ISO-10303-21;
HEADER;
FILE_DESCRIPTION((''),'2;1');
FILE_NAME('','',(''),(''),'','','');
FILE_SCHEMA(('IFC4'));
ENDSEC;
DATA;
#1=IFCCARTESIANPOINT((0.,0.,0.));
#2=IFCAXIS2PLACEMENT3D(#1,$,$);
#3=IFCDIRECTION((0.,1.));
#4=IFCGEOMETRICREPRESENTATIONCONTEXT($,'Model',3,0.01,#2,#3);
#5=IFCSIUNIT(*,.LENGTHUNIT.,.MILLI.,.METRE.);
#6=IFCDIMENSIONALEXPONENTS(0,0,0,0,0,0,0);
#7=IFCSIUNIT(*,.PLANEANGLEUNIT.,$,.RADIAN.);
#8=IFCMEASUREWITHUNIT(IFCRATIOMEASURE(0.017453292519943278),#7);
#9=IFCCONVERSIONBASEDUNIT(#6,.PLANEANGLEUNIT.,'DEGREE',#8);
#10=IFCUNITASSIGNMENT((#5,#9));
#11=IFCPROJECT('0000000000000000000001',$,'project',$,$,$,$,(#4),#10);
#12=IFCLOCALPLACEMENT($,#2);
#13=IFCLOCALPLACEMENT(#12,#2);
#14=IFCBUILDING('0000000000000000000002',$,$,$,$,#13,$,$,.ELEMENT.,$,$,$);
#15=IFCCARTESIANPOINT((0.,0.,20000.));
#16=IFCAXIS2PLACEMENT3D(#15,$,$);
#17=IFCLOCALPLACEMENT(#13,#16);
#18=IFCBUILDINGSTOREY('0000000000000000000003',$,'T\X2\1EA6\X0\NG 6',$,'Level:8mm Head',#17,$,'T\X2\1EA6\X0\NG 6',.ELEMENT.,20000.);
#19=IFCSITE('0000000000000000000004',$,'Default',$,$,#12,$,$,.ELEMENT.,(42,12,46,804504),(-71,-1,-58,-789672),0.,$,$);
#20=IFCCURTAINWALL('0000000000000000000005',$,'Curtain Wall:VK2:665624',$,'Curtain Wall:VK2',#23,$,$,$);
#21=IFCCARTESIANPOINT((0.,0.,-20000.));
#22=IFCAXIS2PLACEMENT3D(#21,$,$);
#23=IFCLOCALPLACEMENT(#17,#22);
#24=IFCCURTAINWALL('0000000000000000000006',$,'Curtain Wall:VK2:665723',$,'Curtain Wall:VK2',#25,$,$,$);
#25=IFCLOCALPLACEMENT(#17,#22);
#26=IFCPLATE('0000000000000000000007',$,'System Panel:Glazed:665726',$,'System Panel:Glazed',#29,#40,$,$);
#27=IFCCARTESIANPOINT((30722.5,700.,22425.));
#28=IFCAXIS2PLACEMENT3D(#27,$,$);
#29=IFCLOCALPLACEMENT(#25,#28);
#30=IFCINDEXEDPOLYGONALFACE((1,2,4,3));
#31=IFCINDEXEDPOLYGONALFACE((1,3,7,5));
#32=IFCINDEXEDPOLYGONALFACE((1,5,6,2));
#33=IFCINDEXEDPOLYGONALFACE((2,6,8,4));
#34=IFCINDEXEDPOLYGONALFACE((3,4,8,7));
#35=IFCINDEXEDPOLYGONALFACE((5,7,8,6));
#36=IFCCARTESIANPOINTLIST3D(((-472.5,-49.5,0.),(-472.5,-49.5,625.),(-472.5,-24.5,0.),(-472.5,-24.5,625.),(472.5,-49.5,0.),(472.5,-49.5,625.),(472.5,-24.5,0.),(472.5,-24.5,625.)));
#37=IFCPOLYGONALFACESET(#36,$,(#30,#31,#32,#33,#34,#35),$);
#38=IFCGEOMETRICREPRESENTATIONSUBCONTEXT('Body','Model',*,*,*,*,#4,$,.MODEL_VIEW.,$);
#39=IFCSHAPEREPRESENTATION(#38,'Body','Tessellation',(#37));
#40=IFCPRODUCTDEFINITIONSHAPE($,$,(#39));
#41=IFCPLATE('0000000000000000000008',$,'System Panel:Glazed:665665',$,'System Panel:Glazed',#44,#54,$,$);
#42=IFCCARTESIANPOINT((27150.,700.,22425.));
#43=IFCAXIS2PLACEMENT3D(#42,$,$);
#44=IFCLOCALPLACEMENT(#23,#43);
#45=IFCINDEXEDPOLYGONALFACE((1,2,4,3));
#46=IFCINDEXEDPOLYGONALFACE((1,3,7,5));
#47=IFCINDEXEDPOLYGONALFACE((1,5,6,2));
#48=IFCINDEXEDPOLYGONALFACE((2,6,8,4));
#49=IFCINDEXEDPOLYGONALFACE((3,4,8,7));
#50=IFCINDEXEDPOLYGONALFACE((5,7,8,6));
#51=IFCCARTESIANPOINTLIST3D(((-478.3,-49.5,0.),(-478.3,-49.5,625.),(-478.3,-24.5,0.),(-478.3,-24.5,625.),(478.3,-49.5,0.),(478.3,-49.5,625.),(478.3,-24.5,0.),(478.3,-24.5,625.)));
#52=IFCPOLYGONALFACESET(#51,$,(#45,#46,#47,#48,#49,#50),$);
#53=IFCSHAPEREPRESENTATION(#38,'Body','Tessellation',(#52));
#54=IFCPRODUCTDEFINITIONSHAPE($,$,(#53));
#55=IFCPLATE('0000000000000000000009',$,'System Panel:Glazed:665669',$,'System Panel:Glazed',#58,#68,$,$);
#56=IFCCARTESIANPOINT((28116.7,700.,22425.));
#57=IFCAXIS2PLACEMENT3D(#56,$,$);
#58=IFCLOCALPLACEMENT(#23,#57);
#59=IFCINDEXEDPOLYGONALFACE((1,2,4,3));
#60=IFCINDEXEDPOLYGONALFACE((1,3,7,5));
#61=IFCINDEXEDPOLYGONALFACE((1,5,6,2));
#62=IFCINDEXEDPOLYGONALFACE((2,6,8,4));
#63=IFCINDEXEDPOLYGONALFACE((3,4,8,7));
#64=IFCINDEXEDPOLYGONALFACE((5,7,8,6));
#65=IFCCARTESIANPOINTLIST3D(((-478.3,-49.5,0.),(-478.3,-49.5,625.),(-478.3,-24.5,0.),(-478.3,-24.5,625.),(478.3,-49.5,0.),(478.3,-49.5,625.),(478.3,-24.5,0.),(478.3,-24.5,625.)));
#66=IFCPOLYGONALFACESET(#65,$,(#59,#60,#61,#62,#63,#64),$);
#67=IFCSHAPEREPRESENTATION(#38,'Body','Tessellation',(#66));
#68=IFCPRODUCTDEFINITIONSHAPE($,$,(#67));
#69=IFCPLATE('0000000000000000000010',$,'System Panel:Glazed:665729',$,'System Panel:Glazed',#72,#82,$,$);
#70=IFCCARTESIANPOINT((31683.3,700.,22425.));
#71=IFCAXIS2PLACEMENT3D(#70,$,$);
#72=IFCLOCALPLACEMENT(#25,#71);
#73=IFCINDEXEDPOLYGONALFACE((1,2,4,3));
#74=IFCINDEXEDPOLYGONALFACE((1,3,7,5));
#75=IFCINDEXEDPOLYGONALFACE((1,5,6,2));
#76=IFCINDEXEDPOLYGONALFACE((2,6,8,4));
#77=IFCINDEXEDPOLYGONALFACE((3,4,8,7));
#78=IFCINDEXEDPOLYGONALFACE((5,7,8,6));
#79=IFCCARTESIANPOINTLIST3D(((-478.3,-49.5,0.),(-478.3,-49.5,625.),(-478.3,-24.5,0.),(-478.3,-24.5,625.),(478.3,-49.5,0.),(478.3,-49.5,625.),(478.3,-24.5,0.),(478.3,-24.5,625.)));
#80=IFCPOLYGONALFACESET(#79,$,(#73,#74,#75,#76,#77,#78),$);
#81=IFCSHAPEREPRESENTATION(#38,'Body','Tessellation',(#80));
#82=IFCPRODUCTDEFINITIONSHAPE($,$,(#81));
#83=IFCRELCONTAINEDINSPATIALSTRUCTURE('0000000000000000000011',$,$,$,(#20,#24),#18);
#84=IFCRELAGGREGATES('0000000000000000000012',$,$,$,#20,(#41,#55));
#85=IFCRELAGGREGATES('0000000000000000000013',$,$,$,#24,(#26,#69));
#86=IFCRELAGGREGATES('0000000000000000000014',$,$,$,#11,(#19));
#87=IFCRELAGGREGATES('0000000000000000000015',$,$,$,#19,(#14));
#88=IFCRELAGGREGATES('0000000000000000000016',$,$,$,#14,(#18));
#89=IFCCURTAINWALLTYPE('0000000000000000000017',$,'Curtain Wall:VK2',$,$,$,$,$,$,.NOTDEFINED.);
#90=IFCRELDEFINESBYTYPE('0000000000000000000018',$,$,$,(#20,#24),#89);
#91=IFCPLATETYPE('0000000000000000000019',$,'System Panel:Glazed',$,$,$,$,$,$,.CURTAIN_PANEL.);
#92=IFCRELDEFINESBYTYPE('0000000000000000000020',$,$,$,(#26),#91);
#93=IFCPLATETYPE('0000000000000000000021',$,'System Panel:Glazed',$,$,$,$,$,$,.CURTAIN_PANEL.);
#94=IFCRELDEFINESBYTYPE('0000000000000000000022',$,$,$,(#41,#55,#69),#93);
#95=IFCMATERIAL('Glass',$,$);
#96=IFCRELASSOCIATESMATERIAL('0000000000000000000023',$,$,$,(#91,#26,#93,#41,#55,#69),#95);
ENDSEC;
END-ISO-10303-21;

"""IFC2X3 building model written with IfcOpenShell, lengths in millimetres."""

from ifc_helpers import new_model, entity, si_unit, converted_unit, direction, frame, frame_2d, origin, place, context, subcontext, project, spatial, rectangle, extrude, source, transform, mapped, material, type_object, type_shapes, element, aggregate, save


model = new_model("IFC2X3")

# Units and contexts
model_context = context("Model", 3, precision=0.01, world=origin(), true_north=direction((0.0, 1.0)))
body_context = subcontext(model_context, "Body", "Model", "MODEL_VIEW")
ifc_project = project(units=[si_unit("LENGTHUNIT", "METRE", prefix="MILLI"), converted_unit("PLANEANGLEUNIT", "DEGREE", entity("IfcRatioMeasure", 0.017453292519943278), si_unit("PLANEANGLEUNIT", "RADIAN"), dimensions=[0, 0, 0, 0, 0, 0, 0])], contexts=[model_context])

# Site, building, storey
site_placement = place(None, origin())
site = spatial("IfcSite", under=ifc_project, at=site_placement, Name="Default", CompositionType="ELEMENT", RefLatitude=(42, 12, 46, 804504), RefLongitude=(-71, -1, -58, -789672), RefElevation=0.0)
building_placement = place(site_placement, origin())
building = spatial("IfcBuilding", under=site, at=building_placement, CompositionType="ELEMENT")
storey_placement = place(building_placement, frame((0.0, 0.0, 20000.0)))
storey = spatial("IfcBuildingStorey", under=building, at=storey_placement, Name="TẦNG 6", ObjectType="Level:8mm Head", LongName="TẦNG 6", CompositionType="ELEMENT", Elevation=20000.0)

# Curtain wall
curtain_wall_type = type_object("IfcCurtainWallType", Name="Curtain Wall:VK2", PredefinedType="NOTDEFINED")
curtain_wall_1_placement = place(storey_placement, frame((0.0, 0.0, -20000.0)))
curtain_wall_1 = element("IfcCurtainWall", 1, at=curtain_wall_1_placement, inside=storey, type_object=curtain_wall_type, Name="Curtain Wall:VK2:665624", ObjectType="Curtain Wall:VK2")

# Curtain wall
curtain_wall_2_placement = place(storey_placement, frame((0.0, 0.0, -20000.0)))
curtain_wall_2 = element("IfcCurtainWall", 2, at=curtain_wall_2_placement, inside=storey, type_object=curtain_wall_type, Name="Curtain Wall:VK2:665723", ObjectType="Curtain Wall:VK2")

# Plates
ifc_material_1 = material(Name="Glass")
plate_type_1 = type_object("IfcPlateType", Name="System Panel:Glazed", PredefinedType="CURTAIN_PANEL", material=ifc_material_1)
shared_shape_1 = source(origin(), body_context, "Body", "SweptSolid", [
    extrude(rectangle(XDim=25.0, YDim=945.0, at=frame_2d((0.0, 0.0), x_axis=(1.0, 0.0))), frame((0.0, -37.0, 0.0), z_axis=(0.0, 0.0, 1.0), x_axis=(0.0, 1.0, 0.0)), (0.0, 0.0, 1.0), 625.0),
])
type_shapes(plate_type_1, [shared_shape_1])
plate_1_placement = place(curtain_wall_2_placement, frame((30722.5, 700.0, 22425.0)))
plate_1 = element("IfcPlate", 3, at=plate_1_placement, type_object=plate_type_1, material=ifc_material_1, Name="System Panel:Glazed:665726", ObjectType="System Panel:Glazed", context=body_context, shape_type="MappedRepresentation", body=[
    mapped(shared_shape_1, transform((0.0, 0.0, 0.0), scale=1.0)),
])
plate_type_2 = type_object("IfcPlateType", Name="System Panel:Glazed", PredefinedType="CURTAIN_PANEL", material=ifc_material_1)
shared_shape_2 = source(origin(), body_context, "Body", "SweptSolid", [
    extrude(rectangle(XDim=25.0, YDim=956.7, at=frame_2d((0.0, 0.0), x_axis=(1.0, 0.0))), frame((0.0, -37.0, 0.0), z_axis=(0.0, 0.0, 1.0), x_axis=(0.0, 1.0, 0.0)), (0.0, 0.0, 1.0), 625.0),
])
type_shapes(plate_type_2, [shared_shape_2])
plate_2_placement = place(curtain_wall_1_placement, frame((27150.0, 700.0, 22425.0)))
plate_2 = element("IfcPlate", 4, at=plate_2_placement, type_object=plate_type_2, material=ifc_material_1, Name="System Panel:Glazed:665665", ObjectType="System Panel:Glazed", context=body_context, shape_type="MappedRepresentation", body=[
    mapped(shared_shape_2, transform((0.0, 0.0, 0.0), scale=1.0)),
])
plate_3_placement = place(curtain_wall_1_placement, frame((28116.7, 700.0, 22425.0)))
plate_3 = element("IfcPlate", 5, at=plate_3_placement, type_object=plate_type_2, material=ifc_material_1, Name="System Panel:Glazed:665669", ObjectType="System Panel:Glazed", context=body_context, shape_type="MappedRepresentation", body=[
    mapped(shared_shape_2, transform((0.0, 0.0, 0.0), scale=1.0)),
])
aggregate(curtain_wall_1, [plate_2, plate_3])
plate_4_placement = place(curtain_wall_2_placement, frame((31683.3, 700.0, 22425.0)))
plate_4 = element("IfcPlate", 6, at=plate_4_placement, type_object=plate_type_2, material=ifc_material_1, Name="System Panel:Glazed:665729", ObjectType="System Panel:Glazed", context=body_context, shape_type="MappedRepresentation", body=[
    mapped(shared_shape_2, transform((0.0, 0.0, 0.0), scale=1.0)),
])
aggregate(curtain_wall_2, [plate_1, plate_4])

save(model, "model.ifc")
